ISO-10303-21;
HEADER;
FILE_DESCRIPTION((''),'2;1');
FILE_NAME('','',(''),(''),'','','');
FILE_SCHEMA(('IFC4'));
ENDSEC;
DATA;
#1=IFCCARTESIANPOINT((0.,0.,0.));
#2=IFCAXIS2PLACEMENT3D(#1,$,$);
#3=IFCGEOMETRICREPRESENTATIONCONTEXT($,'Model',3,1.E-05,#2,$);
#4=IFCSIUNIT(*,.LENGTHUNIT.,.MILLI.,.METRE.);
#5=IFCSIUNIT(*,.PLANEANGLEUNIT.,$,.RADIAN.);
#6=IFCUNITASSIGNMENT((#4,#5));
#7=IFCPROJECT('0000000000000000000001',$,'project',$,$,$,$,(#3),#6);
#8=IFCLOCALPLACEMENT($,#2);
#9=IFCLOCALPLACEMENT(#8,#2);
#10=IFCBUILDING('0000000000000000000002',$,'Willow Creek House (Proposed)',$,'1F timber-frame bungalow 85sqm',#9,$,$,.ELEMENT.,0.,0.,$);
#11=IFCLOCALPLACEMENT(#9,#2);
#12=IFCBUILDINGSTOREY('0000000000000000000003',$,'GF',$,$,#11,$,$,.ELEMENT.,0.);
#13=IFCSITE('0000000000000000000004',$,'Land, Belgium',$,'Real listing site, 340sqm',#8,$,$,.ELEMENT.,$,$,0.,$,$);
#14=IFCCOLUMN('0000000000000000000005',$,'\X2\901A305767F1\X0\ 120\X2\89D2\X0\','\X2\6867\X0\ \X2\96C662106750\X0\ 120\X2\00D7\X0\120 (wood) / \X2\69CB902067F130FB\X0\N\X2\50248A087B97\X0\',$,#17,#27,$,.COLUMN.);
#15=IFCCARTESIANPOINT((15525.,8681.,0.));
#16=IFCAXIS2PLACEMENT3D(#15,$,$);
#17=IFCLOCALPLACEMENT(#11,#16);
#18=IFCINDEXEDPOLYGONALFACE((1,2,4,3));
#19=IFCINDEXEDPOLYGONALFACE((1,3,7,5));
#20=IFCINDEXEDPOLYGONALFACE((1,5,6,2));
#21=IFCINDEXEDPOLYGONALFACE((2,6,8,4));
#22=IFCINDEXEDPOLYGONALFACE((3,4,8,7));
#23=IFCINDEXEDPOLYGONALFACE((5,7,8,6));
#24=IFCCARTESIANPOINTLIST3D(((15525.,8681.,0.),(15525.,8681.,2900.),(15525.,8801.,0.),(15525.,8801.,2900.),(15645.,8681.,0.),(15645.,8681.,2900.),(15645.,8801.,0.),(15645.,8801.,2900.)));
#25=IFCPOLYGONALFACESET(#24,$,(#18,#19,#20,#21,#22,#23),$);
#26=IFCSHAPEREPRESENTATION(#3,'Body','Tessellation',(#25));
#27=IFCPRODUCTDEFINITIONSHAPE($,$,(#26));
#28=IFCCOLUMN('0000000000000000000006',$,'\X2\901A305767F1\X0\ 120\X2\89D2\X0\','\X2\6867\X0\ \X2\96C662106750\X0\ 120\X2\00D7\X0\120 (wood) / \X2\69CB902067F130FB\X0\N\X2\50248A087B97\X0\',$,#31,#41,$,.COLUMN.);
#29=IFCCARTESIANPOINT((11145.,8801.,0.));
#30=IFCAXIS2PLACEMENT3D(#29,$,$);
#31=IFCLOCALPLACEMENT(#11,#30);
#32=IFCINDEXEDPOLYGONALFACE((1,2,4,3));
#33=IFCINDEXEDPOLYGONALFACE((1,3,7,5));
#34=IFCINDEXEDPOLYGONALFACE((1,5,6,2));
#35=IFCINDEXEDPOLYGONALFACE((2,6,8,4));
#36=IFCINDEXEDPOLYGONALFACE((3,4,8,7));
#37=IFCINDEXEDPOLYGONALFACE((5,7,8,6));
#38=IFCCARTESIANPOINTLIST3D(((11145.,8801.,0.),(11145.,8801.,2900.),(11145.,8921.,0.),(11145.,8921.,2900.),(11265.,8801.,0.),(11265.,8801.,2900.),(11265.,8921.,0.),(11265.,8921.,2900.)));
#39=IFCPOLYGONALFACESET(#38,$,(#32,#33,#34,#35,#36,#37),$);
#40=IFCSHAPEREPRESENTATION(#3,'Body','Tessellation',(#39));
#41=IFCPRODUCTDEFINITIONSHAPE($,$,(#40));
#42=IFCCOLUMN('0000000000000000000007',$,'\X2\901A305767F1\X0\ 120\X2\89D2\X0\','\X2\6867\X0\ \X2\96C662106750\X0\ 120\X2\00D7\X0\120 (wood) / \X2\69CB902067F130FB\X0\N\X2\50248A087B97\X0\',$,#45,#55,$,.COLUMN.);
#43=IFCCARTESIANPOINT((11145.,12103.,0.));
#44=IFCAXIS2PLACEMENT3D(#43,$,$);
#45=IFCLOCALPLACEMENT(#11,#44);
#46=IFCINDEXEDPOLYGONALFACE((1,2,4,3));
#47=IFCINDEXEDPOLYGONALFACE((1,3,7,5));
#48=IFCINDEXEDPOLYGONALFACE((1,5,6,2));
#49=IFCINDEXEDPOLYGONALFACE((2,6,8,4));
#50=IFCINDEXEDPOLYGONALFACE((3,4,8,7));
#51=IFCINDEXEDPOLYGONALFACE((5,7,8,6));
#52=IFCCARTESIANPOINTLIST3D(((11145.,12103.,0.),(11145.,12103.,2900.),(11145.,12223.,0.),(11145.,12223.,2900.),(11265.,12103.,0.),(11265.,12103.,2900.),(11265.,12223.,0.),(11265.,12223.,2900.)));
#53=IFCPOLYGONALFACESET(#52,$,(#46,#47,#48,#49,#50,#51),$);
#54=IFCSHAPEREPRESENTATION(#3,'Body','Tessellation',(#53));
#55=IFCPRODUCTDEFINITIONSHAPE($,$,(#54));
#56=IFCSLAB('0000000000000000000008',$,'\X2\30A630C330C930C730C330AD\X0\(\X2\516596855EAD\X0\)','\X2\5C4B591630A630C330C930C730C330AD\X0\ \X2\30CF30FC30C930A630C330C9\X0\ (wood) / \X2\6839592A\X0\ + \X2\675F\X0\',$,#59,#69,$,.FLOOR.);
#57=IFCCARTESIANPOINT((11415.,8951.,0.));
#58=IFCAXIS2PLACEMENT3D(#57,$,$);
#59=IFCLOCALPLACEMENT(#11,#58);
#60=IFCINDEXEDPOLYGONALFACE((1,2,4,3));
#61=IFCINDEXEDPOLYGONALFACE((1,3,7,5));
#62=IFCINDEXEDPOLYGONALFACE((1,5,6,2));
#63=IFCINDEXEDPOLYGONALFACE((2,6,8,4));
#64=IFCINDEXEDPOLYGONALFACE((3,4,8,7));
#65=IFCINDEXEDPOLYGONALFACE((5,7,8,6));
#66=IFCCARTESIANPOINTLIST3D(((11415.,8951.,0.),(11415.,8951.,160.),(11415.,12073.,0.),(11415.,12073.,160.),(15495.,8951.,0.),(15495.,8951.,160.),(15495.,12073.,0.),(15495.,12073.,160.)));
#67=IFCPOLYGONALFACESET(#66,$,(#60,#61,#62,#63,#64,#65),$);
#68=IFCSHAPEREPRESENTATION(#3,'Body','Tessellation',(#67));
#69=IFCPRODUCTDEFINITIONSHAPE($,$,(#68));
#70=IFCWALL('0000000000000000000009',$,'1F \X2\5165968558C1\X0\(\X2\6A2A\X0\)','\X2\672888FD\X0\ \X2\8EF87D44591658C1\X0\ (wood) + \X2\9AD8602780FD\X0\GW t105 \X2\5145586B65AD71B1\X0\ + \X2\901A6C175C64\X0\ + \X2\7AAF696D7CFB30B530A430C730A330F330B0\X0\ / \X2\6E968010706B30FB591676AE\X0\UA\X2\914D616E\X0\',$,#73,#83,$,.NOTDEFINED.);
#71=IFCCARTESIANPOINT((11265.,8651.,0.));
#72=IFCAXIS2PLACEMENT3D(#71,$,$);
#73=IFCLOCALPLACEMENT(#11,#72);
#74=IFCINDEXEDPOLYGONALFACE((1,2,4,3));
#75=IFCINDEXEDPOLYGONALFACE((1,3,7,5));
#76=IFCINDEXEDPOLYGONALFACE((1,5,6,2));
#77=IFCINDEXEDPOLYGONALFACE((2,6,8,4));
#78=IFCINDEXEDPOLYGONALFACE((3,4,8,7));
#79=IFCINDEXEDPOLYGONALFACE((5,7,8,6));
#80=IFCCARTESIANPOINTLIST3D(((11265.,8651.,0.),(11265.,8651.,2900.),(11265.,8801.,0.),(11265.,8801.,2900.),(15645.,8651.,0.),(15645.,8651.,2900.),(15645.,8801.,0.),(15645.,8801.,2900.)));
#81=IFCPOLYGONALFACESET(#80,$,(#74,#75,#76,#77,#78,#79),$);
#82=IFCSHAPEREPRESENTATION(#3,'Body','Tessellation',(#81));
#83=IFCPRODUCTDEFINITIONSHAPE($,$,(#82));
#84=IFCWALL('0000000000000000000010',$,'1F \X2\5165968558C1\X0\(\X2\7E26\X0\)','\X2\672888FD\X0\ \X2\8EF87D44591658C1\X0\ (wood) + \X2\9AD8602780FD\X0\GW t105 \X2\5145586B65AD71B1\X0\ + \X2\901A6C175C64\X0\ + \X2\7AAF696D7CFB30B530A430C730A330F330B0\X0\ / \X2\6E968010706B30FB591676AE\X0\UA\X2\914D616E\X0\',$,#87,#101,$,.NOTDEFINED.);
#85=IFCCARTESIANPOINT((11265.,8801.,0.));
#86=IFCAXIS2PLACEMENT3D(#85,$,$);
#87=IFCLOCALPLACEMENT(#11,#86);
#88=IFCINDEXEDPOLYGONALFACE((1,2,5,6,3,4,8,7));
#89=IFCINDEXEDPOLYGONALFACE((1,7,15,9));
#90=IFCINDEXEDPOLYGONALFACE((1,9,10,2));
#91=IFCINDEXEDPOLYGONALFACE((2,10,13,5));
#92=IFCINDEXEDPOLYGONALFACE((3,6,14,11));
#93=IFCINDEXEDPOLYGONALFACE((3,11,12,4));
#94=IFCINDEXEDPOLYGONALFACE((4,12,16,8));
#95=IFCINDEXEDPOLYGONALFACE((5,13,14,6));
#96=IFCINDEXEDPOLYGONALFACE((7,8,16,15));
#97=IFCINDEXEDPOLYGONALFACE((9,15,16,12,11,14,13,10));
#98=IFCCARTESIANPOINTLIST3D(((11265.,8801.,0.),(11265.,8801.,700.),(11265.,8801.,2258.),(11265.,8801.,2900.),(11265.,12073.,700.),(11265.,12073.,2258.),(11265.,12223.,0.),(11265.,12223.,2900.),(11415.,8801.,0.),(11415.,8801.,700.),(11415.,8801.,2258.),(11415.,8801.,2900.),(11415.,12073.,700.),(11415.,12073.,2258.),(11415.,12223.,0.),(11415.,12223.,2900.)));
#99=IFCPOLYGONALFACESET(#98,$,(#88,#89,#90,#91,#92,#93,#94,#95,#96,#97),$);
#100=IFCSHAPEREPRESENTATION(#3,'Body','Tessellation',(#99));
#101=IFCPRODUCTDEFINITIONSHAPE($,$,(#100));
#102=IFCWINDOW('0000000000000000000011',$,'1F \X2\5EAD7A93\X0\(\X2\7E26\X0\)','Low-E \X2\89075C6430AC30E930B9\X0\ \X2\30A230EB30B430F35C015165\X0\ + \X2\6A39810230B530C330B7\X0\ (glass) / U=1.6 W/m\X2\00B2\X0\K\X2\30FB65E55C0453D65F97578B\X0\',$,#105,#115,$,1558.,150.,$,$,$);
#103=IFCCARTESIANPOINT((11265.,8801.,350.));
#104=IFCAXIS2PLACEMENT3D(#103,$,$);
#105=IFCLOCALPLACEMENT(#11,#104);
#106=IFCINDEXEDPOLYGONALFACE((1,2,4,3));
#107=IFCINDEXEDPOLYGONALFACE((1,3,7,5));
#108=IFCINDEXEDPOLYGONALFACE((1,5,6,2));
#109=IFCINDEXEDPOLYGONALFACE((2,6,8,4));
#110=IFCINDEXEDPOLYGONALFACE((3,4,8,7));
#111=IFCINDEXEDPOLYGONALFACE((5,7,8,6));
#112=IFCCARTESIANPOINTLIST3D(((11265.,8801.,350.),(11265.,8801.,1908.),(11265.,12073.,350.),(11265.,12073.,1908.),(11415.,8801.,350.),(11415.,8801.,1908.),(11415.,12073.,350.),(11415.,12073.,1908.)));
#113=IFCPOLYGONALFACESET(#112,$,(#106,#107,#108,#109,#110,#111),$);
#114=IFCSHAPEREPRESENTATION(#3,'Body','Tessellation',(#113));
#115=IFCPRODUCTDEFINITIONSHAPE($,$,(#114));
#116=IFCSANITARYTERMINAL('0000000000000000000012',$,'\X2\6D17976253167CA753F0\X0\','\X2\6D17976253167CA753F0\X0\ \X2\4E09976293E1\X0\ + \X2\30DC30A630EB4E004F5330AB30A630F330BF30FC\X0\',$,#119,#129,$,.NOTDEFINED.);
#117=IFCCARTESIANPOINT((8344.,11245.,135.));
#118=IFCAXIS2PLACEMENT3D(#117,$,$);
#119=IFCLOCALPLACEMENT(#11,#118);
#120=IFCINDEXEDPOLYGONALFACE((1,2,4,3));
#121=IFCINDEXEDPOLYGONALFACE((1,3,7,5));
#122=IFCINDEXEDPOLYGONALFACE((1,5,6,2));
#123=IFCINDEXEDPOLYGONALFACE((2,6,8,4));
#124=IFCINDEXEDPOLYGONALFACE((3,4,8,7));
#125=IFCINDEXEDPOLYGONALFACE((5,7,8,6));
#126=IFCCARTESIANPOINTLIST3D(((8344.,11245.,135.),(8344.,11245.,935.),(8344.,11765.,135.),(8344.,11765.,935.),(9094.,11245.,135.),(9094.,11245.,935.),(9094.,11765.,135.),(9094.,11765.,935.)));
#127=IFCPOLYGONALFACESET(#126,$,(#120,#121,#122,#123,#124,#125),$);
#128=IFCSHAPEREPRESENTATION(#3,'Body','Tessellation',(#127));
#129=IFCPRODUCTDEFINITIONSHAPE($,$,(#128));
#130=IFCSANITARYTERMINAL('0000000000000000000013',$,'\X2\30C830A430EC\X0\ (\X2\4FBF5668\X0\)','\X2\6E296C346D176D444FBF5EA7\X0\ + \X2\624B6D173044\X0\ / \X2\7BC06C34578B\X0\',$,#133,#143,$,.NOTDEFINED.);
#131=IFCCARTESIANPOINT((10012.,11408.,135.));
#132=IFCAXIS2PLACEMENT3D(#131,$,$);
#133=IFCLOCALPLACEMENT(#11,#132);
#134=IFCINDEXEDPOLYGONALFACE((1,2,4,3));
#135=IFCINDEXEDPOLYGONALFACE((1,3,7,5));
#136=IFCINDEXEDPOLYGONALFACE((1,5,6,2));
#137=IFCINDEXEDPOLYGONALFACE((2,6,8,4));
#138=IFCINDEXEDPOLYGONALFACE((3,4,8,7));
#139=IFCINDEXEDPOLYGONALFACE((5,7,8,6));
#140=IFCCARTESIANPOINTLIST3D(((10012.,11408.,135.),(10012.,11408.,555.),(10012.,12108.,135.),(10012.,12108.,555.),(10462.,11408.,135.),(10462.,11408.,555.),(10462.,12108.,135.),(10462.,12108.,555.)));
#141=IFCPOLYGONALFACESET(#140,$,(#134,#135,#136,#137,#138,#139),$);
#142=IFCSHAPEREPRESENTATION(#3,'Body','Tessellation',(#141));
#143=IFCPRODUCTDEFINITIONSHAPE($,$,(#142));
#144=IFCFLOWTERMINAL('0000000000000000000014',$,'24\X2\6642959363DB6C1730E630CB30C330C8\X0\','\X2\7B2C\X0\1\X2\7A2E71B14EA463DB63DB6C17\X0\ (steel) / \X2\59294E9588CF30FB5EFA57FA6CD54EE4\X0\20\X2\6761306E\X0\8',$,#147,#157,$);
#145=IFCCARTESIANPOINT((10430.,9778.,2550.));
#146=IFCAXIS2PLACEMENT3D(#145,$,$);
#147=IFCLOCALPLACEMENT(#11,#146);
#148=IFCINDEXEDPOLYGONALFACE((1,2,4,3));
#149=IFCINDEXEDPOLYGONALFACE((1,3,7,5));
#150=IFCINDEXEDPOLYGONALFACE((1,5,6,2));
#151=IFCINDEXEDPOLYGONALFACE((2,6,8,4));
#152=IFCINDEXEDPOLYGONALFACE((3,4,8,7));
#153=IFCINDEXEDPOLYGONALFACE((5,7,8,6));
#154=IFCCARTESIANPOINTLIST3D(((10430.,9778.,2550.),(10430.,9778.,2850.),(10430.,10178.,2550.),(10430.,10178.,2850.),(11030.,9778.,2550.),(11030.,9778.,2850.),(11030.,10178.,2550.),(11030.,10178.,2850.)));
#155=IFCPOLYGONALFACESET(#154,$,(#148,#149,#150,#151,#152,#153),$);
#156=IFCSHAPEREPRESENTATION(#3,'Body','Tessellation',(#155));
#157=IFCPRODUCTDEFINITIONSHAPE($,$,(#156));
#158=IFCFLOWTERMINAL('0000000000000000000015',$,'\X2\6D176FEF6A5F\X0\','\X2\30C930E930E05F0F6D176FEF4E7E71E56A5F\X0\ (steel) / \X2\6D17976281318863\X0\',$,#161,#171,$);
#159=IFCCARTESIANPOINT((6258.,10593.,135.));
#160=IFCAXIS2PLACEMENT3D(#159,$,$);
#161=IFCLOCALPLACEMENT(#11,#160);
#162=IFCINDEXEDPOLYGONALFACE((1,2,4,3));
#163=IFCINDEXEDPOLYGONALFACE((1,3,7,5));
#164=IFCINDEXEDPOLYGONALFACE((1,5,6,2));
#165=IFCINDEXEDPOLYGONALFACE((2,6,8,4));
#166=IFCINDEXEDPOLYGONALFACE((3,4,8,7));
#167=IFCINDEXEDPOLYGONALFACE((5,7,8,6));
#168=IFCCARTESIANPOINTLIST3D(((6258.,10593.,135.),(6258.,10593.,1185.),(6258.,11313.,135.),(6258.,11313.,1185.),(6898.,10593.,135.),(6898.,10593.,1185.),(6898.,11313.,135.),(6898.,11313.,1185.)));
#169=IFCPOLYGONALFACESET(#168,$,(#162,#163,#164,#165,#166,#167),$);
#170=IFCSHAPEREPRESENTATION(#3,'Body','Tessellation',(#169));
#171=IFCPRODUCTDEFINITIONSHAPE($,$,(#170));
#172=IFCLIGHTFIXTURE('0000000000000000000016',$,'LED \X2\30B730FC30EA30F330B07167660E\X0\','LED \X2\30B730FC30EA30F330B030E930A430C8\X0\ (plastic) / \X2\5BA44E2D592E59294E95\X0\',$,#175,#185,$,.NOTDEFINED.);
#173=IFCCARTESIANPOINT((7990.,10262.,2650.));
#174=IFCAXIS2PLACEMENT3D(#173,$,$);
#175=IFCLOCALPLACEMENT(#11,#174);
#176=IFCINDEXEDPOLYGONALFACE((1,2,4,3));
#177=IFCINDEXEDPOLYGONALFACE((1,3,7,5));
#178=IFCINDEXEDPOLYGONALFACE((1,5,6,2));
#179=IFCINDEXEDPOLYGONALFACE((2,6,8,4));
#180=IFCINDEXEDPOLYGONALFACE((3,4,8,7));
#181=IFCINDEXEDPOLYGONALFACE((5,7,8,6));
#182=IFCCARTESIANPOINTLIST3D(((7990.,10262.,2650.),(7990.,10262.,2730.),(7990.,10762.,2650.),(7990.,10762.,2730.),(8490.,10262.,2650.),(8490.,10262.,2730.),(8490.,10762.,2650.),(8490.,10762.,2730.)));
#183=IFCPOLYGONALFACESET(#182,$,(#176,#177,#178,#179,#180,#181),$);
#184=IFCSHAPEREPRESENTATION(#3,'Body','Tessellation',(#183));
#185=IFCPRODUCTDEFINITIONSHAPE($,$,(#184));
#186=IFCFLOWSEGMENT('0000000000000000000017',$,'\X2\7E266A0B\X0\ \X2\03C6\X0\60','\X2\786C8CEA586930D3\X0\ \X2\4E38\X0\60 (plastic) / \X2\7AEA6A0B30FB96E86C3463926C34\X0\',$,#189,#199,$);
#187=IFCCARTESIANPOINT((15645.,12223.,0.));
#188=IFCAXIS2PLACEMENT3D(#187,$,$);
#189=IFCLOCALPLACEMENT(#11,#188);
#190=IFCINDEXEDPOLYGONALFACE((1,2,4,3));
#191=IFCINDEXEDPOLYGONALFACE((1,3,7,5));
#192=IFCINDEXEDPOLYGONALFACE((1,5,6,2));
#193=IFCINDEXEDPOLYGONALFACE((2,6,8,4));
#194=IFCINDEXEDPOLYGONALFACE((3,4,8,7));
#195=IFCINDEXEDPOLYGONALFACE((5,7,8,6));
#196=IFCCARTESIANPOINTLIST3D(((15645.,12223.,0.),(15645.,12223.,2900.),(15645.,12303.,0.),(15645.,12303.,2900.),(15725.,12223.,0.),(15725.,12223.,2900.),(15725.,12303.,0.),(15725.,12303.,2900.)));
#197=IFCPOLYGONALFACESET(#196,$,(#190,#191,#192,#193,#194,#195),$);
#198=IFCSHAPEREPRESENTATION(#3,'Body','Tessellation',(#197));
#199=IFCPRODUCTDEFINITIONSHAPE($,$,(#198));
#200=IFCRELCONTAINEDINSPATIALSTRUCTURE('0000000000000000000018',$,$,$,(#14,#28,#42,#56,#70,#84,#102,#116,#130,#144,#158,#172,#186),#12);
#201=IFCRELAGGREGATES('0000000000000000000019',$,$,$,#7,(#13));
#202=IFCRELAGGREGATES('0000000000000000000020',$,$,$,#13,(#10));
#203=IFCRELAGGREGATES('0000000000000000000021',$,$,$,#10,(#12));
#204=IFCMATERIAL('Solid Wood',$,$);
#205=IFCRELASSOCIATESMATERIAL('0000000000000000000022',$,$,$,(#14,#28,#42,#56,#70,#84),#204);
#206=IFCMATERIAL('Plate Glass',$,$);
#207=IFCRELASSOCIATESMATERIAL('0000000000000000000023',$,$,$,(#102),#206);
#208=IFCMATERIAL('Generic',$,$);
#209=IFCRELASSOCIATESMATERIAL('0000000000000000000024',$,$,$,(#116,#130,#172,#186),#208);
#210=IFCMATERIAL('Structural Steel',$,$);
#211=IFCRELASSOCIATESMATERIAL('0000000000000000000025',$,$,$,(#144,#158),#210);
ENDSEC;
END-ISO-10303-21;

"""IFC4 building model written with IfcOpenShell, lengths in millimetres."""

from ifc_helpers import new_model, si_unit, frame, frame_2d, origin, place, context, project, spatial, rectangle, extrude, material, element, fill, save


model = new_model("IFC4")

# Units and contexts
model_context = context("Model", 3, precision=1e-05, world=origin())
ifc_project = project(units=[si_unit("LENGTHUNIT", "METRE", prefix="MILLI"), si_unit("PLANEANGLEUNIT", "RADIAN")], contexts=[model_context])

# Site, building, storey
site_placement = place(None, origin())
site = spatial("IfcSite", under=ifc_project, at=site_placement, Name="Land, Belgium", ObjectType="Real listing site, 340sqm", CompositionType="ELEMENT", RefElevation=0.0)
building_placement = place(site_placement, origin())
building = spatial("IfcBuilding", under=site, at=building_placement, Name="Willow Creek House (Proposed)", ObjectType="1F timber-frame bungalow 85sqm", CompositionType="ELEMENT", ElevationOfRefHeight=0.0, ElevationOfTerrain=0.0)
storey_placement = place(building_placement, origin())
storey = spatial("IfcBuildingStorey", under=building, at=storey_placement, Name="GF", CompositionType="ELEMENT", Elevation=0.0)

# Columns
ifc_material_1 = material(Name="Solid Wood")
column_1_placement = place(storey_placement, frame((15525.0, 8681.0, 0.0)))
element("IfcColumn", 1, at=column_1_placement, inside=storey, material=ifc_material_1, Name="通し柱 120角", Description="桧 集成材 120×120 (wood) / 構造柱・N値計算", PredefinedType="COLUMN", context=model_context, shape_type="SweptSolid", body=[
    extrude(rectangle(XDim=120.0, YDim=120.0, at=frame_2d((60.0, 60.0))), frame((15525.0, 8681.0, 0.0)), (0.0, 0.0, 1.0), 2900.0),
])
column_2_placement = place(storey_placement, frame((11145.0, 8801.0, 0.0)))
element("IfcColumn", 2, at=column_2_placement, inside=storey, material=ifc_material_1, Name="通し柱 120角", Description="桧 集成材 120×120 (wood) / 構造柱・N値計算", PredefinedType="COLUMN", context=model_context, shape_type="SweptSolid", body=[
    extrude(rectangle(XDim=120.0, YDim=120.0, at=frame_2d((60.0, 60.0))), frame((11145.0, 8801.0, 0.0)), (0.0, 0.0, 1.0), 2900.0),
])
column_3_placement = place(storey_placement, frame((11145.0, 12103.0, 0.0)))
element("IfcColumn", 3, at=column_3_placement, inside=storey, material=ifc_material_1, Name="通し柱 120角", Description="桧 集成材 120×120 (wood) / 構造柱・N値計算", PredefinedType="COLUMN", context=model_context, shape_type="SweptSolid", body=[
    extrude(rectangle(XDim=120.0, YDim=120.0, at=frame_2d((60.0, 60.0))), frame((11145.0, 12103.0, 0.0)), (0.0, 0.0, 1.0), 2900.0),
])

# Slab
slab_placement = place(storey_placement, frame((11415.0, 8951.0, 0.0)))
element("IfcSlab", 4, at=slab_placement, inside=storey, material=ifc_material_1, Name="ウッドデッキ(入隅庭)", Description="屋外ウッドデッキ ハードウッド (wood) / 根太 + 束", PredefinedType="FLOOR", context=model_context, shape_type="SweptSolid", body=[
    extrude(rectangle(XDim=4080.0, YDim=3122.0, at=frame_2d((2040.0, 1561.0))), frame((11415.0, 8951.0, 0.0)), (0.0, 0.0, 1.0), 160.0),
])

# Wall
wall_1_placement = place(storey_placement, frame((11265.0, 8651.0, 0.0)))
element("IfcWall", 5, at=wall_1_placement, inside=storey, material=ifc_material_1, Name="1F 入隅壁(横)", Description="木製 軸組外壁 (wood) + 高性能GW t105 充填断熱 + 通気層 + 窯業系サイディング / 準耐火・外皮UA配慮", PredefinedType="NOTDEFINED", context=model_context, shape_type="SweptSolid", body=[
    extrude(rectangle(XDim=4380.0, YDim=150.0, at=frame_2d((2190.0, 75.0))), frame((11265.0, 8651.0, 0.0)), (0.0, 0.0, 1.0), 2900.0),
])

# Wall, opening, window
wall_2_placement = place(storey_placement, frame((11265.0, 8801.0, 0.0)))
wall_2 = element("IfcWall", 6, at=wall_2_placement, inside=storey, material=ifc_material_1, Name="1F 入隅壁(縦)", Description="木製 軸組外壁 (wood) + 高性能GW t105 充填断熱 + 通気層 + 窯業系サイディング / 準耐火・外皮UA配慮", PredefinedType="NOTDEFINED", context=model_context, shape_type="SweptSolid", body=[
    extrude(rectangle(XDim=150.0, YDim=3422.0, at=frame_2d((75.0, 1711.0))), frame((11265.0, 8801.0, 0.0)), (0.0, 0.0, 1.0), 2900.0),
])
opening_placement = place(storey_placement, frame((11265.0, 8801.0, 350.0)))
opening = element("IfcOpeningElement", 7, at=opening_placement, cuts=wall_2, PredefinedType="NOTDEFINED", context=model_context, shape_type="SweptSolid", body=[
    extrude(rectangle(XDim=150.0, YDim=3272.0, at=frame_2d((75.0, 1636.0))), frame((11265.0, 8801.0, 350.0)), (0.0, 0.0, 1.0), 1558.0),
])
ifc_material_2 = material(Name="Plate Glass")
window_placement = place(storey_placement, frame((11265.0, 8801.0, 350.0)))
window = element("IfcWindow", 8, at=window_placement, inside=storey, material=ifc_material_2, Name="1F 庭窓(縦)", Description="Low-E 複層ガラス アルゴン封入 + 樹脂サッシ (glass) / U=1.6 W/m²K・日射取得型", OverallHeight=1558.0, OverallWidth=150.0, context=model_context, shape_type="SweptSolid", body=[
    extrude(rectangle(XDim=150.0, YDim=3272.0, at=frame_2d((75.0, 1636.0))), frame((11265.0, 8801.0, 350.0)), (0.0, 0.0, 1.0), 1558.0),
])
fill(opening, window)

# Sanitary terminals
ifc_material_3 = material(Name="Generic")
sanitary_terminal_1_placement = place(storey_placement, frame((8344.0, 11245.0, 135.0)))
element("IfcSanitaryTerminal", 9, at=sanitary_terminal_1_placement, inside=storey, material=ifc_material_3, Name="洗面化粧台", Description="洗面化粧台 三面鏡 + ボウル一体カウンター", PredefinedType="NOTDEFINED", context=model_context, shape_type="SweptSolid", body=[
    extrude(rectangle(XDim=750.0, YDim=520.0, at=frame_2d((375.0, 260.0))), frame((8344.0, 11245.0, 135.0)), (0.0, 0.0, 1.0), 800.0),
])
sanitary_terminal_2_placement = place(storey_placement, frame((10012.0, 11408.0, 135.0)))
element("IfcSanitaryTerminal", 10, at=sanitary_terminal_2_placement, inside=storey, material=ifc_material_3, Name="トイレ (便器)", Description="温水洗浄便座 + 手洗い / 節水型", PredefinedType="NOTDEFINED", context=model_context, shape_type="SweptSolid", body=[
    extrude(rectangle(XDim=450.0, YDim=700.0, at=frame_2d((225.0, 350.0))), frame((10012.0, 11408.0, 135.0)), (0.0, 0.0, 1.0), 420.0),
])

# Flow terminals
ifc_material_4 = material(Name="Structural Steel")
flow_terminal_1_placement = place(storey_placement, frame((10430.0, 9778.0, 2550.0)))
element("IfcFlowTerminal", 11, at=flow_terminal_1_placement, inside=storey, material=ifc_material_4, Name="24時間換気ユニット", Description="第1種熱交換換気 (steel) / 天井裏・建基法令20条の8", context=model_context, shape_type="SweptSolid", body=[
    extrude(rectangle(XDim=600.0, YDim=400.0, at=frame_2d((300.0, 200.0))), frame((10430.0, 9778.0, 2550.0)), (0.0, 0.0, 1.0), 300.0),
])
flow_terminal_2_placement = place(storey_placement, frame((6258.0, 10593.0, 135.0)))
element("IfcFlowTerminal", 12, at=flow_terminal_2_placement, inside=storey, material=ifc_material_4, Name="洗濯機", Description="ドラム式洗濯乾燥機 (steel) / 洗面脱衣", context=model_context, shape_type="SweptSolid", body=[
    extrude(rectangle(XDim=640.0, YDim=720.0, at=frame_2d((320.0, 360.0))), frame((6258.0, 10593.0, 135.0)), (0.0, 0.0, 1.0), 1050.0),
])

# Light fixture
light_fixture_placement = place(storey_placement, frame((7990.0, 10262.0, 2650.0)))
element("IfcLightFixture", 13, at=light_fixture_placement, inside=storey, material=ifc_material_3, Name="LED シーリング照明", Description="LED シーリングライト (plastic) / 室中央天井", PredefinedType="NOTDEFINED", context=model_context, shape_type="SweptSolid", body=[
    extrude(rectangle(XDim=500.0, YDim=500.0, at=frame_2d((250.0, 250.0))), frame((7990.0, 10262.0, 2650.0)), (0.0, 0.0, 1.0), 80.0),
])

# Flow segment
flow_segment_placement = place(storey_placement, frame((15645.0, 12223.0, 0.0)))
element("IfcFlowSegment", 14, at=flow_segment_placement, inside=storey, material=ifc_material_3, Name="縦樋 φ60", Description="硬質塩ビ 丸60 (plastic) / 竪樋・雨水排水", context=model_context, shape_type="SweptSolid", body=[
    extrude(rectangle(XDim=80.0, YDim=80.0, at=frame_2d((40.0, 40.0))), frame((15645.0, 12223.0, 0.0)), (0.0, 0.0, 1.0), 2900.0),
])

save(model, "model.ifc")
